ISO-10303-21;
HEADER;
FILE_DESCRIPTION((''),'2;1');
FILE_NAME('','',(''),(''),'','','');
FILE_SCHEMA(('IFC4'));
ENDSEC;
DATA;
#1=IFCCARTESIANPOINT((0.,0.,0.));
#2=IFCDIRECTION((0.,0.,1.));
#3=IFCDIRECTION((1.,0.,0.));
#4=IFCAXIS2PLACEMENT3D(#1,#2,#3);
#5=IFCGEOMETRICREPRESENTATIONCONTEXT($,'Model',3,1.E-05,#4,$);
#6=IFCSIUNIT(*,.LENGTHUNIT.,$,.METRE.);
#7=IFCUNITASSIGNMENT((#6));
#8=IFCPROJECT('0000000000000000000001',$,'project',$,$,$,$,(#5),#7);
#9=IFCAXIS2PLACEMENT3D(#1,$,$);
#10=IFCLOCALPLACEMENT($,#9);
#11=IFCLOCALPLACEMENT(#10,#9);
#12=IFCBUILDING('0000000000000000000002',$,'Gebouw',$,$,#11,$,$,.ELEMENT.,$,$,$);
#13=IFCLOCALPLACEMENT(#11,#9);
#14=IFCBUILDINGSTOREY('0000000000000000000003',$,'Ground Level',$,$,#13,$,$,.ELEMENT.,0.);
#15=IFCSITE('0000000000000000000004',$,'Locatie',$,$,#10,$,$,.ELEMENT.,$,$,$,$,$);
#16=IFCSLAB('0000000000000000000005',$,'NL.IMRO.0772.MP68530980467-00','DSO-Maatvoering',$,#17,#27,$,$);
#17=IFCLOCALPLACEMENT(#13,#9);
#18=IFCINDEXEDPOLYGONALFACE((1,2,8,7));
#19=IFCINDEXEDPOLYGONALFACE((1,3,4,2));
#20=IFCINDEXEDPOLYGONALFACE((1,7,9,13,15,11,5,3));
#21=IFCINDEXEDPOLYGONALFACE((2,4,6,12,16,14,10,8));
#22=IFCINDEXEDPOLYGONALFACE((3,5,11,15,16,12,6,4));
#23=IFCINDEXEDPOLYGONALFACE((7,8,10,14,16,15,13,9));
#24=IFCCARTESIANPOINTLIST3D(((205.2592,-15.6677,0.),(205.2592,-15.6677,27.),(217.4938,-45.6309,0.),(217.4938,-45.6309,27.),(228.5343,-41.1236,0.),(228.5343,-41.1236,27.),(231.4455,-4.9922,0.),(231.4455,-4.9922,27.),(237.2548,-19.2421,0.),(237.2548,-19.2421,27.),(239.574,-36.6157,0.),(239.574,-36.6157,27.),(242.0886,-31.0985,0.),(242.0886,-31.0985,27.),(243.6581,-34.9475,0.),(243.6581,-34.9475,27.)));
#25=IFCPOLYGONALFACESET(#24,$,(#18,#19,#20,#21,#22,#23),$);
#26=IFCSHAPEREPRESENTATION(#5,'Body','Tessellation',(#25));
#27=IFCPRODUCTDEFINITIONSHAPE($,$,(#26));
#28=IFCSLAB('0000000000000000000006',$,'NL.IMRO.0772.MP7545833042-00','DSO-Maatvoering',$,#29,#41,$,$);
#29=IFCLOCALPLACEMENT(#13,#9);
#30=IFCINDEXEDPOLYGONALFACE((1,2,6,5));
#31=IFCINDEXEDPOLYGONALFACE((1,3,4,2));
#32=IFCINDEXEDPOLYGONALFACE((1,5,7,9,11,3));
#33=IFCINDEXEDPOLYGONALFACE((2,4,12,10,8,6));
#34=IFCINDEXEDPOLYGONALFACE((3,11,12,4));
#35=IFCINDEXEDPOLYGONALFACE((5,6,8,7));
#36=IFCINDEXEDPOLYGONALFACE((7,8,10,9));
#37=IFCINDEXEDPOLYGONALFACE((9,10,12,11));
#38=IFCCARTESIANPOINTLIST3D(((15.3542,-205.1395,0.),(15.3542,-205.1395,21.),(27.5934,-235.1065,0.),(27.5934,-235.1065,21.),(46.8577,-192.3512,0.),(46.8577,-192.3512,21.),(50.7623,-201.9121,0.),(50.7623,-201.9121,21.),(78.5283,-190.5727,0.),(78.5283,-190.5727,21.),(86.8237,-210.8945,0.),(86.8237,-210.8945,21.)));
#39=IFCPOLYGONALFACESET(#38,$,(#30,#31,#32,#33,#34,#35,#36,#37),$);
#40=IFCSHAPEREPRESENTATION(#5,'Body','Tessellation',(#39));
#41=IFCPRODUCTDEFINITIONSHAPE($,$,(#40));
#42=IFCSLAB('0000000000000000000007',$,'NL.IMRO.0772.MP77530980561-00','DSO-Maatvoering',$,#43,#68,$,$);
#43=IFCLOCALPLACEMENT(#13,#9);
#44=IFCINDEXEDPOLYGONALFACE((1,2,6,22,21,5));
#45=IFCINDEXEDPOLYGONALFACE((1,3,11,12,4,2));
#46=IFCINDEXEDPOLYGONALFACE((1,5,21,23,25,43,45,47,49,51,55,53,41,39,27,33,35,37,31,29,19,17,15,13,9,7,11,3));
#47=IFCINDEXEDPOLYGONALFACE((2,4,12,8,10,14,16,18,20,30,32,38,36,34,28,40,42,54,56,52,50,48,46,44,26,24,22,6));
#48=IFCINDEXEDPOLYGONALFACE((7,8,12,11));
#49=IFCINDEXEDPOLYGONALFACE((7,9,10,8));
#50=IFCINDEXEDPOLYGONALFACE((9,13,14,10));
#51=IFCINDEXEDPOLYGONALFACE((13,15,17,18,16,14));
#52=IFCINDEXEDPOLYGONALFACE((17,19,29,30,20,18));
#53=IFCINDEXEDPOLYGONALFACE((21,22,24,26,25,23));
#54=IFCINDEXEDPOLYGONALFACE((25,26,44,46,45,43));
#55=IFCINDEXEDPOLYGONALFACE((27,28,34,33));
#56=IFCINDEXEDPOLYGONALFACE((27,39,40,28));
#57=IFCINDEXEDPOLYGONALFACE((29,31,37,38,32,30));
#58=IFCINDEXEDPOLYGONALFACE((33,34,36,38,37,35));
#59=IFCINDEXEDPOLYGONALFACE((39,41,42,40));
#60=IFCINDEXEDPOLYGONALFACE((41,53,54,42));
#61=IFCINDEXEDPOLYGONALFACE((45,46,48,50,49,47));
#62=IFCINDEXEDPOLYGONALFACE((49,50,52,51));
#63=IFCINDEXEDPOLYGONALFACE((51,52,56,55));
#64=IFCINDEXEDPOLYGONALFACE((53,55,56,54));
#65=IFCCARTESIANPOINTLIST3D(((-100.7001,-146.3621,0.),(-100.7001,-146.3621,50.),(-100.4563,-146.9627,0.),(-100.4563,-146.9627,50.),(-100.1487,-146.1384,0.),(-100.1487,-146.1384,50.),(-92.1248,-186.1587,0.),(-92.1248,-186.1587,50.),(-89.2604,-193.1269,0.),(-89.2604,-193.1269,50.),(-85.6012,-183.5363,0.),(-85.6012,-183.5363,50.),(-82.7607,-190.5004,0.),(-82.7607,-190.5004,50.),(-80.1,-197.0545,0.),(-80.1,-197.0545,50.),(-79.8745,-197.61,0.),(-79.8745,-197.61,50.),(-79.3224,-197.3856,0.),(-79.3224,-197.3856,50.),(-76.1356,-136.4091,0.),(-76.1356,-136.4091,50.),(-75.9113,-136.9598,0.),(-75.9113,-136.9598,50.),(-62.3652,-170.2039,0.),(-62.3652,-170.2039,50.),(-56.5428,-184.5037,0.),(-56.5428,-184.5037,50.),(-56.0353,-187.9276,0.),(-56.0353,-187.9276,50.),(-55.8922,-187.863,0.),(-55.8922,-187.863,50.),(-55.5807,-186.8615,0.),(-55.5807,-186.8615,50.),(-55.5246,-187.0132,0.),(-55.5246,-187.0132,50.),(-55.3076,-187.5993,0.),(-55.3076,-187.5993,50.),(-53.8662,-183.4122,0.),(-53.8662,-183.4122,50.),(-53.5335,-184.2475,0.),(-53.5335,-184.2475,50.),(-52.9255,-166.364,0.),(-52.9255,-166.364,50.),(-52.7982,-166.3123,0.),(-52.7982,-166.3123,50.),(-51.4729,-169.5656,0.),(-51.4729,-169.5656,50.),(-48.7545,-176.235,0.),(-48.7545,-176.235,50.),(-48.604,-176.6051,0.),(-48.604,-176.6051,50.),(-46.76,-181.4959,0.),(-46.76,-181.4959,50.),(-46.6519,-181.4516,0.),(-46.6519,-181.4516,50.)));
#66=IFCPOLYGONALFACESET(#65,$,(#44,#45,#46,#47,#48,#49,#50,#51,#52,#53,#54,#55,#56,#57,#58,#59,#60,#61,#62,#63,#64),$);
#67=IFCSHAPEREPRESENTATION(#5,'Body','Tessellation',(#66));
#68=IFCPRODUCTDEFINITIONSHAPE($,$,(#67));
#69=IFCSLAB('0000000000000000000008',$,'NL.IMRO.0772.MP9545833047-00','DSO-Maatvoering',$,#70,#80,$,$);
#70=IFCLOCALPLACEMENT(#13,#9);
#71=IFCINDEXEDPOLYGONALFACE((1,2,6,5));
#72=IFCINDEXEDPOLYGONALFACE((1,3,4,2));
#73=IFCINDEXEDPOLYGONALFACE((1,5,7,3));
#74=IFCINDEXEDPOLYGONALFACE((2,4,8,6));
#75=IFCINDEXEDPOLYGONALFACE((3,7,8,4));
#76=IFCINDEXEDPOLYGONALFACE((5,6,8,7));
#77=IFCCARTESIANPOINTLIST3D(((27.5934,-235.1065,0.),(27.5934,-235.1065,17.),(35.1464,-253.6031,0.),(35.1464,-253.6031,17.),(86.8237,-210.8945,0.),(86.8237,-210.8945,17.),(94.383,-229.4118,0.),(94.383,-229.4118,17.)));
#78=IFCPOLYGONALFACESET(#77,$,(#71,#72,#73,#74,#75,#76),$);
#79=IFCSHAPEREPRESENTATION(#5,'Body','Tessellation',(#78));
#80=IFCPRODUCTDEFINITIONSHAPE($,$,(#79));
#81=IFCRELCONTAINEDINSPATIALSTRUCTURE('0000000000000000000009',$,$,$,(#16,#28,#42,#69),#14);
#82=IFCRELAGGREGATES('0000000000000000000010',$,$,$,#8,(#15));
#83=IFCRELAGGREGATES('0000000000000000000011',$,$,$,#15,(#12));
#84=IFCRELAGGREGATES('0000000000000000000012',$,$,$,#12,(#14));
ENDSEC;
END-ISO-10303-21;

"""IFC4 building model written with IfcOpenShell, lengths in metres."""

from ifc_helpers import new_model, si_unit, origin, origin_with_axes, place, context, project, spatial, polyline, outline, extrude, element, save


model = new_model("IFC4")

# Units and contexts
model_context = context("Model", 3, precision=1e-05, world=origin_with_axes())
ifc_project = project(units=[si_unit("LENGTHUNIT", "METRE")], contexts=[model_context])

# Site, building, storey
site_placement = place(None, origin())
site = spatial("IfcSite", under=ifc_project, at=site_placement, Name="Locatie", CompositionType="ELEMENT")
building_placement = place(site_placement, origin())
building = spatial("IfcBuilding", under=site, at=building_placement, Name="Gebouw", CompositionType="ELEMENT")
storey_placement = place(building_placement, origin())
storey = spatial("IfcBuildingStorey", under=building, at=storey_placement, Name="Ground Level", CompositionType="ELEMENT", Elevation=0.0)

# Slabs
slab_1_placement = place(storey_placement, origin())
element("IfcSlab", 1, at=slab_1_placement, inside=storey, Name="NL.IMRO.0772.MP68530980467-00", Description="DSO-Maatvoering", context=model_context, shape_type="SweptSolid", body=[
    extrude(outline(polyline([(243.6581, -34.9475), (239.574, -36.6157), (228.5343, -41.1236), (217.4938, -45.6309), (205.2592, -15.6677), (231.4455, -4.9922), (237.2548, -19.2421), (242.0886, -31.0985), (243.6581, -34.9475)])), origin_with_axes(), (0.0, 0.0, 1.0), 27.0),
])
slab_2_placement = place(storey_placement, origin())
element("IfcSlab", 2, at=slab_2_placement, inside=storey, Name="NL.IMRO.0772.MP7545833042-00", Description="DSO-Maatvoering", context=model_context, shape_type="SweptSolid", body=[
    extrude(outline(polyline([(78.5283, -190.5727), (86.8237, -210.8945), (27.5934, -235.1065), (15.3542, -205.1395), (46.8577, -192.3512), (50.7623, -201.9121), (78.5283, -190.5727)])), origin_with_axes(), (0.0, 0.0, 1.0), 21.0),
])
slab_3_placement = place(storey_placement, origin())
element("IfcSlab", 3, at=slab_3_placement, inside=storey, Name="NL.IMRO.0772.MP77530980561-00", Description="DSO-Maatvoering", context=model_context, shape_type="SweptSolid", body=[
    extrude(outline(polyline([(-52.7982, -166.3123), (-51.4729, -169.5656), (-48.7545, -176.235), (-48.604, -176.6051), (-46.6519, -181.4516), (-46.76, -181.4959), (-53.5335, -184.2475), (-53.8662, -183.4122), (-56.5428, -184.5037), (-55.5807, -186.8615), (-55.5246, -187.0132), (-55.3076, -187.5993), (-55.8922, -187.863), (-56.0353, -187.9276), (-79.3224, -197.3856), (-79.8745, -197.61), (-80.1, -197.0545), (-82.7607, -190.5004), (-89.2604, -193.1269), (-92.1248, -186.1587), (-85.6012, -183.5363), (-100.4563, -146.9627), (-100.7001, -146.3621), (-100.1487, -146.1384), (-76.1356, -136.4091), (-75.9113, -136.9598), (-62.3652, -170.2039), (-52.9255, -166.364), (-52.7982, -166.3123)])), origin_with_axes(), (0.0, 0.0, 1.0), 50.0),
])
slab_4_placement = place(storey_placement, origin())
element("IfcSlab", 4, at=slab_4_placement, inside=storey, Name="NL.IMRO.0772.MP9545833047-00", Description="DSO-Maatvoering", context=model_context, shape_type="SweptSolid", body=[
    extrude(outline(polyline([(86.8237, -210.8945), (94.383, -229.4118), (35.1464, -253.6031), (27.5934, -235.1065), (86.8237, -210.8945)])), origin_with_axes(), (0.0, 0.0, 1.0), 17.0),
])

save(model, "model.ifc")
